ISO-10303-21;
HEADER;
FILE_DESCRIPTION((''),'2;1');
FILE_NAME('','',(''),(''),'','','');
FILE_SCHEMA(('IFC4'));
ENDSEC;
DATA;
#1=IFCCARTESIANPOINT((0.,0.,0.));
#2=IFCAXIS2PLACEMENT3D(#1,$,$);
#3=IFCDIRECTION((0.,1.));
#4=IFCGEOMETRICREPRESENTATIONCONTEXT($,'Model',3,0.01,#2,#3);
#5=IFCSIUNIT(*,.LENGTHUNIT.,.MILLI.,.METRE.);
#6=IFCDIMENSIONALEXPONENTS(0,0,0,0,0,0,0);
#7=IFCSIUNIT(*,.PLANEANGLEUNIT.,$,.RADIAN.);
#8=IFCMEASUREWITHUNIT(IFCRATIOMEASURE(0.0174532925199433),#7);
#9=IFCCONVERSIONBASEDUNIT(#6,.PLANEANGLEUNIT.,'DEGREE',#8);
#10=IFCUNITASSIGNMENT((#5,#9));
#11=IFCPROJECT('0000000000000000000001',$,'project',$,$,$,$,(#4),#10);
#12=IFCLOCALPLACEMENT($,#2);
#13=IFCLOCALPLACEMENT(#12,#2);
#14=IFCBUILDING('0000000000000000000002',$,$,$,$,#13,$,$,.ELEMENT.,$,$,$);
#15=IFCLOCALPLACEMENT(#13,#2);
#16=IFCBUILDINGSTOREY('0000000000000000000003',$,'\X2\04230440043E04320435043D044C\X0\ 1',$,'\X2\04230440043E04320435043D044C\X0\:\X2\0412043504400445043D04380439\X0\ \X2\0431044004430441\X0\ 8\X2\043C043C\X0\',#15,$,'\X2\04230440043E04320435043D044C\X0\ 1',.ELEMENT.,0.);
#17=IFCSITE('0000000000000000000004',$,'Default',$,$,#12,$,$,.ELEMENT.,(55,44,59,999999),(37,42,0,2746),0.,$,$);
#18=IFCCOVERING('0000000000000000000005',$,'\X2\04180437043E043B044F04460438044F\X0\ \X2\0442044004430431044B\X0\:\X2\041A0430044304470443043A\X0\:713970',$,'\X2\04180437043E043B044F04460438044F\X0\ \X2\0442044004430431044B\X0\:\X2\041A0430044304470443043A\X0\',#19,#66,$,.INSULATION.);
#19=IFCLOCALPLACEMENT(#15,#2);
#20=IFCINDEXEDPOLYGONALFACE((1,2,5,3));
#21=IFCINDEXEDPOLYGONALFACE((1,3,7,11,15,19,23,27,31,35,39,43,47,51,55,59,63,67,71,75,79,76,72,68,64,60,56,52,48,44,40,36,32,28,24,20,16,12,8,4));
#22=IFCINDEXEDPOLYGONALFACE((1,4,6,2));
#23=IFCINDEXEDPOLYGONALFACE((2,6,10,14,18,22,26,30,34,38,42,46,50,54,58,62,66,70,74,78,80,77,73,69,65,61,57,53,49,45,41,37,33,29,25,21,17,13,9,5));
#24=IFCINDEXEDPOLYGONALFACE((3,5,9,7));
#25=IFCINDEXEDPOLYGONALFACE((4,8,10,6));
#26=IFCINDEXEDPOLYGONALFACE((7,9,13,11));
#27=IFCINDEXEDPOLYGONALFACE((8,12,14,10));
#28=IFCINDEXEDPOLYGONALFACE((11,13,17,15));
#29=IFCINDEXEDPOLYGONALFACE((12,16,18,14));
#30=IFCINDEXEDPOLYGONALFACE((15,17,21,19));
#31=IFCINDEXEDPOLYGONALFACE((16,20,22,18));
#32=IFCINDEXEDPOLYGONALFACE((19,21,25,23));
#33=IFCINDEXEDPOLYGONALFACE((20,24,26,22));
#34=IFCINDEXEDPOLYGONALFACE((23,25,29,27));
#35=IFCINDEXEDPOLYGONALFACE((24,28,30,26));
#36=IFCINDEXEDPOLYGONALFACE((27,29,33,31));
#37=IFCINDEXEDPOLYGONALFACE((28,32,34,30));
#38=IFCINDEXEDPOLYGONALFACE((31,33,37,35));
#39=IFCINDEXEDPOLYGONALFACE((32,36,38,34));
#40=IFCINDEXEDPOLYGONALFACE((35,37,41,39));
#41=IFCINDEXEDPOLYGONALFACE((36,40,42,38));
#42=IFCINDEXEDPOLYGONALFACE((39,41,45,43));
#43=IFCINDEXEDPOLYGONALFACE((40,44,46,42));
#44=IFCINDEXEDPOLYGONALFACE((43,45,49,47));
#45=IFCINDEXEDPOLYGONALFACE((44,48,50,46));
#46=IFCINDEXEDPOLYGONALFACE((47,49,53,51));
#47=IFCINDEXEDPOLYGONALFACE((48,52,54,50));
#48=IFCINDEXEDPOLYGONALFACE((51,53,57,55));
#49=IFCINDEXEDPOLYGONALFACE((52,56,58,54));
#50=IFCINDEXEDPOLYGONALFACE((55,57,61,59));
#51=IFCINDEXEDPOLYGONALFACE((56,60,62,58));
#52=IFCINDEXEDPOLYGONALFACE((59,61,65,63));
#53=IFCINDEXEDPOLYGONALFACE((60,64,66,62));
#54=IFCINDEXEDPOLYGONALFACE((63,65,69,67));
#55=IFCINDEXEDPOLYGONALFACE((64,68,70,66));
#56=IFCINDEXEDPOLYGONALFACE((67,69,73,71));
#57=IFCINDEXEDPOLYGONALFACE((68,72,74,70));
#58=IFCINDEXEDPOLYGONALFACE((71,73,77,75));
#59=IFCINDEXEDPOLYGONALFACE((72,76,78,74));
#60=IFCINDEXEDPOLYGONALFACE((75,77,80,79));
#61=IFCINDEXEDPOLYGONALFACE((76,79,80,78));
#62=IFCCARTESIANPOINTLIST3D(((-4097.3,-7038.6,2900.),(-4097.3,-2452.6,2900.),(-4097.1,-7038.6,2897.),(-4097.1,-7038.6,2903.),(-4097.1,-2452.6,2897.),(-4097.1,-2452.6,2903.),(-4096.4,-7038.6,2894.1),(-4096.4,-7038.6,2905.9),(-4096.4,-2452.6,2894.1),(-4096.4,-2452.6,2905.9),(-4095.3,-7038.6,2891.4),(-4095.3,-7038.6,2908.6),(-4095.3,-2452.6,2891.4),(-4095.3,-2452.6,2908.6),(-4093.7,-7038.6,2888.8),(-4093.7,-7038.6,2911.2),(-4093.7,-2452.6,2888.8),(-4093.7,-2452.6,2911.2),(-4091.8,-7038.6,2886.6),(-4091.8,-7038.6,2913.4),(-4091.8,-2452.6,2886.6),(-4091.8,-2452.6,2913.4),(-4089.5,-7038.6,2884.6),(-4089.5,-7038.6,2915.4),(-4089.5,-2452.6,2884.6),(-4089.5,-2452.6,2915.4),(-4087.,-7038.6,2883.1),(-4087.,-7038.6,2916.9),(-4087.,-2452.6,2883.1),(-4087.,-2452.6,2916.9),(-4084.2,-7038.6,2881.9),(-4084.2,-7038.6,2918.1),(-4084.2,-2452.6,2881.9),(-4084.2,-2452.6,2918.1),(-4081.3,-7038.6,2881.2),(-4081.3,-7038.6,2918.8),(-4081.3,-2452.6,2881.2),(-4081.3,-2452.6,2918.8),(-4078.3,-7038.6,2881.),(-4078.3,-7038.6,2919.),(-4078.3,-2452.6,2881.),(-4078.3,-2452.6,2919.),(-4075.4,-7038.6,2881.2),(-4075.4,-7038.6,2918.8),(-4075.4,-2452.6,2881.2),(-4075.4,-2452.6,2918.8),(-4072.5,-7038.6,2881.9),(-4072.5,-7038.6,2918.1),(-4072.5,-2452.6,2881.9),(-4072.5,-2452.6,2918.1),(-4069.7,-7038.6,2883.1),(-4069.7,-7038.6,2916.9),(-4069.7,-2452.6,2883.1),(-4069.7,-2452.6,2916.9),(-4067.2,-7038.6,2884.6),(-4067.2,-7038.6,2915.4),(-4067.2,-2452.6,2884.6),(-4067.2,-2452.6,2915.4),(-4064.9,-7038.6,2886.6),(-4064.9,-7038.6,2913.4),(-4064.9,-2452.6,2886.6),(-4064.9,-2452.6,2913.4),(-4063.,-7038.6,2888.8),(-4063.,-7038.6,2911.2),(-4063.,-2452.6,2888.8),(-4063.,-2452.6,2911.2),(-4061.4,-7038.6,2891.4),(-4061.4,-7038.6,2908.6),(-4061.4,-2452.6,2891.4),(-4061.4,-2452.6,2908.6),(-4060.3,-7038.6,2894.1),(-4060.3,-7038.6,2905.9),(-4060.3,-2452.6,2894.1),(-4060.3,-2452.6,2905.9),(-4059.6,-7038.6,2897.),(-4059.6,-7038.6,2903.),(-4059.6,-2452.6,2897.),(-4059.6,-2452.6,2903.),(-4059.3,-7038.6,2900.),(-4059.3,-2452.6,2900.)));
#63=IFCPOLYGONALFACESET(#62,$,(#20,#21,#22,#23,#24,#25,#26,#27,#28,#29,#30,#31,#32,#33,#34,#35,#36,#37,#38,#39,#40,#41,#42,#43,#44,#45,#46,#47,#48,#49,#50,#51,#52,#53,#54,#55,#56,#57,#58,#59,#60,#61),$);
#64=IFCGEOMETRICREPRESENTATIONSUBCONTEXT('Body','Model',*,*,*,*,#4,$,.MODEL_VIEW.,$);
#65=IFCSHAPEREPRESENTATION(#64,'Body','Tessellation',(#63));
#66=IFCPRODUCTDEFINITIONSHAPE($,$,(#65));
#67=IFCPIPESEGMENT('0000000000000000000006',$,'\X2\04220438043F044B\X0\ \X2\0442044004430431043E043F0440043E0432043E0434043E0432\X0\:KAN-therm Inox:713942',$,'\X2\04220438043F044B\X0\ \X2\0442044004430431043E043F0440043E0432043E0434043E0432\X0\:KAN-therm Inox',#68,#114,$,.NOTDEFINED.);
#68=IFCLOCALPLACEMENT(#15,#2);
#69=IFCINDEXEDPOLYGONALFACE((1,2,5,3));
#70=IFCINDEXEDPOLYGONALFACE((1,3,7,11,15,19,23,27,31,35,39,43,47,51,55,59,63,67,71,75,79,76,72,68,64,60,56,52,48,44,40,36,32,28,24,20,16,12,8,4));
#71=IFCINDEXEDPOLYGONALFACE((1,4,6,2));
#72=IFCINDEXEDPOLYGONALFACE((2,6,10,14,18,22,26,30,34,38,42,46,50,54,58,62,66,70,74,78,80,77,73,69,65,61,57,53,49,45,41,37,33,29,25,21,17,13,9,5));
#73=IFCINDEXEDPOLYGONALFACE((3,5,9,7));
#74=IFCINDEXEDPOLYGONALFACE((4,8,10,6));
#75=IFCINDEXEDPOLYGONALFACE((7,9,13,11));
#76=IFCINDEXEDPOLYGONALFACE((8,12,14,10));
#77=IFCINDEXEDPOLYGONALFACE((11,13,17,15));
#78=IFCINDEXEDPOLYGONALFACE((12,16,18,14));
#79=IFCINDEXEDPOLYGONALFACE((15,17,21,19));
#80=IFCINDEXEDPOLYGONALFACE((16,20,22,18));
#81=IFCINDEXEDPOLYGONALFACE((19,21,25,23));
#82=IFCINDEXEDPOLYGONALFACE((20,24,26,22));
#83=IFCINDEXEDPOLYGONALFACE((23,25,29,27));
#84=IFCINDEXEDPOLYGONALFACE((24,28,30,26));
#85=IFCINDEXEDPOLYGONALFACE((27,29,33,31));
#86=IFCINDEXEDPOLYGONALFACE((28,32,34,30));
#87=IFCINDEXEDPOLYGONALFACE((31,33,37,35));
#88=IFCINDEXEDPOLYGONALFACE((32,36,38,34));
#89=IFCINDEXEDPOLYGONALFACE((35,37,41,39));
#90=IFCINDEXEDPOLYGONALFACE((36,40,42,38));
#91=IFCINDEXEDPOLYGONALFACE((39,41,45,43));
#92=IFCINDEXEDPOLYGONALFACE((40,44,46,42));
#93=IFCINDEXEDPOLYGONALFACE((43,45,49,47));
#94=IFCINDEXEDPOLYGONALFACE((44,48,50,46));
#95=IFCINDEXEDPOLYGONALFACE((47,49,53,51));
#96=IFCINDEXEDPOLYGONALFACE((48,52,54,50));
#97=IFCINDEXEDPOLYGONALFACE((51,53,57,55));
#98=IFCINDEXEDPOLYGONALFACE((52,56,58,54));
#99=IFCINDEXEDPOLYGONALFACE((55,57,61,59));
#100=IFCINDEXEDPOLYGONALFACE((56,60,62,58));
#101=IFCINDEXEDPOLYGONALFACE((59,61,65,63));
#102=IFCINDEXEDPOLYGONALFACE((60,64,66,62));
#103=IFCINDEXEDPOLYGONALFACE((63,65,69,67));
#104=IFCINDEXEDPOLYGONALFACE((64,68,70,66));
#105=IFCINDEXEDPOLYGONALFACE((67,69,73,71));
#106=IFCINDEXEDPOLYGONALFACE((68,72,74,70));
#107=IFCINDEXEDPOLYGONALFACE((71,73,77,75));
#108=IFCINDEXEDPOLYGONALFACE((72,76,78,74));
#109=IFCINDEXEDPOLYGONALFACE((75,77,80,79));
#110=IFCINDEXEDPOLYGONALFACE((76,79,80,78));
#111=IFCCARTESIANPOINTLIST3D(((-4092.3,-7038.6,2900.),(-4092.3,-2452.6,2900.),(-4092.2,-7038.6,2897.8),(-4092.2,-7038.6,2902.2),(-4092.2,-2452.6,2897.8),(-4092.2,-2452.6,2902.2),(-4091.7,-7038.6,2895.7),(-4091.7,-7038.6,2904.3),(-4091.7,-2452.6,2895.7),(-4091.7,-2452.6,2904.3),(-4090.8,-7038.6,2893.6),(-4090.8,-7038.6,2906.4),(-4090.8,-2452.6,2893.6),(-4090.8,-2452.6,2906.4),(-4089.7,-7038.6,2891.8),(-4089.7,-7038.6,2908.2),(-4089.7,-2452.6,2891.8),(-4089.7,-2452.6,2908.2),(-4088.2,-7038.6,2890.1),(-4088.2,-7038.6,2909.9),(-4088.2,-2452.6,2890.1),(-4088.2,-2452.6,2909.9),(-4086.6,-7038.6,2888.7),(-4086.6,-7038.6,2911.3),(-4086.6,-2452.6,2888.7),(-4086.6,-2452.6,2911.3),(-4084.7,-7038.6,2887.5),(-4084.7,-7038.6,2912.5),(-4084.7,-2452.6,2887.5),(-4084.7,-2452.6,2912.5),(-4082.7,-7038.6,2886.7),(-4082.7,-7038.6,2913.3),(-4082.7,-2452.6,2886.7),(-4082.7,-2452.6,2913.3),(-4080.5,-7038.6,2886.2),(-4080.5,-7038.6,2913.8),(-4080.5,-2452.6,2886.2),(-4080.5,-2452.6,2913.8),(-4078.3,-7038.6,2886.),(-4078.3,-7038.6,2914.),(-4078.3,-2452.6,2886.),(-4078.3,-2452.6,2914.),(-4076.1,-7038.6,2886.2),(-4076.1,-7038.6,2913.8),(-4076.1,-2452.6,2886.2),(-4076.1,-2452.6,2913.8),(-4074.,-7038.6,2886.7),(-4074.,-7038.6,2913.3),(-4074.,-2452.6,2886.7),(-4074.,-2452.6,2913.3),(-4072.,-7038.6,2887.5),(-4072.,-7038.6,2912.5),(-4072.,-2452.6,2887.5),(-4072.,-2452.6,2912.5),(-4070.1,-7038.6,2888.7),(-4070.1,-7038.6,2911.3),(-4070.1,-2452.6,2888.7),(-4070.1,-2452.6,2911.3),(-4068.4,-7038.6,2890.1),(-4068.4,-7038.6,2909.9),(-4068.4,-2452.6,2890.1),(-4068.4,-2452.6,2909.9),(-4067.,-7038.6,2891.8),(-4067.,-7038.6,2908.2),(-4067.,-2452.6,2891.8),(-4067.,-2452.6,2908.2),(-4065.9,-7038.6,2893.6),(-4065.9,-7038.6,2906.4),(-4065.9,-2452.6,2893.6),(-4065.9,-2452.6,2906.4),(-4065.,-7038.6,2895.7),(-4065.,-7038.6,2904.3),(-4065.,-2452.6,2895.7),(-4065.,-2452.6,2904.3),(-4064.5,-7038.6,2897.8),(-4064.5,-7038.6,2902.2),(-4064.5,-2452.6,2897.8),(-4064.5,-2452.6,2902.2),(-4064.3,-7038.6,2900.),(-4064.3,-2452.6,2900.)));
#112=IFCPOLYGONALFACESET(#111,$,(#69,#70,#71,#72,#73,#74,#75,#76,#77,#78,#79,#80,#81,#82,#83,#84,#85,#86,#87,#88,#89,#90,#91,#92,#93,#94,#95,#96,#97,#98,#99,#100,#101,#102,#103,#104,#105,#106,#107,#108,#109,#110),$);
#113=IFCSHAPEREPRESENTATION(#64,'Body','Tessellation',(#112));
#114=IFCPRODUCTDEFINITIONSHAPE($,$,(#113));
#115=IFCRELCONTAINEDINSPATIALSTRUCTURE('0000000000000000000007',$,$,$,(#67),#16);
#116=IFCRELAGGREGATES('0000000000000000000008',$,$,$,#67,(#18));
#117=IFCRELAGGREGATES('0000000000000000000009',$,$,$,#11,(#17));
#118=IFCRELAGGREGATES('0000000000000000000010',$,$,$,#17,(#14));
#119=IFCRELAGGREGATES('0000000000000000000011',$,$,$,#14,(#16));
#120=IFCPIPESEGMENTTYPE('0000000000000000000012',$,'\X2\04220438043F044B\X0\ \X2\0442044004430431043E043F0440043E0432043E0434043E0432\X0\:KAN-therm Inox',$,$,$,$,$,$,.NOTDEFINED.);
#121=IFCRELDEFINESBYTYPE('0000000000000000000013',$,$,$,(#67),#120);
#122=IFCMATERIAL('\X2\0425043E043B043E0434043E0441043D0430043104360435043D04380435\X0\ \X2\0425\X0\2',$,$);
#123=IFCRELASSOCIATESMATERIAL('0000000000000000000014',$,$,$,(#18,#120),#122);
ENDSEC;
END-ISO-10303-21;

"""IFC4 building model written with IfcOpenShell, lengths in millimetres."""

from ifc_helpers import new_model, entity, si_unit, converted_unit, direction, frame, origin, place, context, subcontext, project, spatial, indexed_curve, outline, extrude, material, type_object, element, aggregate, save


model = new_model("IFC4")

# Units and contexts
model_context = context("Model", 3, precision=0.01, world=origin(), true_north=direction((0.0, 1.0)))
body_context = subcontext(model_context, "Body", "Model", "MODEL_VIEW")
ifc_project = project(units=[si_unit("LENGTHUNIT", "METRE", prefix="MILLI"), converted_unit("PLANEANGLEUNIT", "DEGREE", entity("IfcRatioMeasure", 0.0174532925199433), si_unit("PLANEANGLEUNIT", "RADIAN"), dimensions=[0, 0, 0, 0, 0, 0, 0])], contexts=[model_context])

# Site, building, storey
site_placement = place(None, origin())
site = spatial("IfcSite", under=ifc_project, at=site_placement, Name="Default", CompositionType="ELEMENT", RefLatitude=(55, 44, 59, 999999), RefLongitude=(37, 42, 0, 2746), RefElevation=0.0)
building_placement = place(site_placement, origin())
building = spatial("IfcBuilding", under=site, at=building_placement, CompositionType="ELEMENT")
storey_placement = place(building_placement, origin())
storey = spatial("IfcBuildingStorey", under=building, at=storey_placement, Name="Уровень 1", ObjectType="Уровень:Верхний брус 8мм", LongName="Уровень 1", CompositionType="ELEMENT", Elevation=0.0)

# Covering
ifc_material_1 = material(Name="Холодоснабжение Х2")
covering_1_placement = place(storey_placement, origin())
covering_1 = element("IfcCovering", 1, at=covering_1_placement, material=ifc_material_1, Name="Изоляция трубы:Каучук:713970", ObjectType="Изоляция трубы:Каучук", PredefinedType="INSULATION", context=body_context, shape_type="SweptSolid", body=[
    extrude(outline(indexed_curve([(19.0, 0.0), (18.8, 3.0), (18.1, 5.9), (16.9, 8.6), (15.4, 11.2), (13.4, 13.4), (11.2, 15.4), (8.6, 16.9), (5.9, 18.1), (3.0, 18.8), (0.0, 19.0), (-3.0, 18.8), (-5.9, 18.1), (-8.6, 16.9), (-11.2, 15.4), (-13.4, 13.4), (-15.4, 11.2), (-16.9, 8.6), (-18.1, 5.9), (-18.8, 3.0), (-19.0, 0.0), (-18.8, -3.0), (-18.1, -5.9), (-16.9, -8.6), (-15.4, -11.2), (-13.4, -13.4), (-11.2, -15.4), (-8.6, -16.9), (-5.9, -18.1), (-3.0, -18.8), (0.0, -19.0), (3.0, -18.8), (5.9, -18.1), (8.6, -16.9), (11.2, -15.4), (13.4, -13.4), (15.4, -11.2), (16.9, -8.6), (18.1, -5.9), (18.8, -3.0), (19.0, 0.0)], self_intersect=False)), frame((-4078.3, -7038.6, 2900.0), z_axis=(0.0, 1.0, 0.0), x_axis=(1.0, 0.0, 0.0)), (0.0, 0.0, 1.0), 4586.0),
])

# Pipe segment
pipe_segment_type_1 = type_object("IfcPipeSegmentType", Name="Типы трубопроводов:KAN-therm Inox", PredefinedType="NOTDEFINED", material=ifc_material_1)
pipe_segment_1_placement = place(storey_placement, origin())
pipe_segment_1 = element("IfcPipeSegment", 2, at=pipe_segment_1_placement, inside=storey, type_object=pipe_segment_type_1, Name="Типы трубопроводов:KAN-therm Inox:713942", ObjectType="Типы трубопроводов:KAN-therm Inox", PredefinedType="NOTDEFINED", context=body_context, shape_type="SweptSolid", body=[
    extrude(outline(indexed_curve([(14.0, 0.0), (13.8, 2.2), (13.3, 4.3), (12.5, 6.4), (11.3, 8.2), (9.9, 9.9), (8.2, 11.3), (6.4, 12.5), (4.3, 13.3), (2.2, 13.8), (0.0, 14.0), (-2.2, 13.8), (-4.3, 13.3), (-6.4, 12.5), (-8.2, 11.3), (-9.9, 9.9), (-11.3, 8.2), (-12.5, 6.4), (-13.3, 4.3), (-13.8, 2.2), (-14.0, 0.0), (-13.8, -2.2), (-13.3, -4.3), (-12.5, -6.4), (-11.3, -8.2), (-9.9, -9.9), (-8.2, -11.3), (-6.4, -12.5), (-4.3, -13.3), (-2.2, -13.8), (0.0, -14.0), (2.2, -13.8), (4.3, -13.3), (6.4, -12.5), (8.2, -11.3), (9.9, -9.9), (11.3, -8.2), (12.5, -6.4), (13.3, -4.3), (13.8, -2.2), (14.0, 0.0)], self_intersect=False)), frame((-4078.3, -7038.6, 2900.0), z_axis=(0.0, 1.0, 0.0), x_axis=(-1.0, 0.0, 0.0)), (0.0, 0.0, 1.0), 4586.0),
])
aggregate(pipe_segment_1, [covering_1])

save(model, "model.ifc")
